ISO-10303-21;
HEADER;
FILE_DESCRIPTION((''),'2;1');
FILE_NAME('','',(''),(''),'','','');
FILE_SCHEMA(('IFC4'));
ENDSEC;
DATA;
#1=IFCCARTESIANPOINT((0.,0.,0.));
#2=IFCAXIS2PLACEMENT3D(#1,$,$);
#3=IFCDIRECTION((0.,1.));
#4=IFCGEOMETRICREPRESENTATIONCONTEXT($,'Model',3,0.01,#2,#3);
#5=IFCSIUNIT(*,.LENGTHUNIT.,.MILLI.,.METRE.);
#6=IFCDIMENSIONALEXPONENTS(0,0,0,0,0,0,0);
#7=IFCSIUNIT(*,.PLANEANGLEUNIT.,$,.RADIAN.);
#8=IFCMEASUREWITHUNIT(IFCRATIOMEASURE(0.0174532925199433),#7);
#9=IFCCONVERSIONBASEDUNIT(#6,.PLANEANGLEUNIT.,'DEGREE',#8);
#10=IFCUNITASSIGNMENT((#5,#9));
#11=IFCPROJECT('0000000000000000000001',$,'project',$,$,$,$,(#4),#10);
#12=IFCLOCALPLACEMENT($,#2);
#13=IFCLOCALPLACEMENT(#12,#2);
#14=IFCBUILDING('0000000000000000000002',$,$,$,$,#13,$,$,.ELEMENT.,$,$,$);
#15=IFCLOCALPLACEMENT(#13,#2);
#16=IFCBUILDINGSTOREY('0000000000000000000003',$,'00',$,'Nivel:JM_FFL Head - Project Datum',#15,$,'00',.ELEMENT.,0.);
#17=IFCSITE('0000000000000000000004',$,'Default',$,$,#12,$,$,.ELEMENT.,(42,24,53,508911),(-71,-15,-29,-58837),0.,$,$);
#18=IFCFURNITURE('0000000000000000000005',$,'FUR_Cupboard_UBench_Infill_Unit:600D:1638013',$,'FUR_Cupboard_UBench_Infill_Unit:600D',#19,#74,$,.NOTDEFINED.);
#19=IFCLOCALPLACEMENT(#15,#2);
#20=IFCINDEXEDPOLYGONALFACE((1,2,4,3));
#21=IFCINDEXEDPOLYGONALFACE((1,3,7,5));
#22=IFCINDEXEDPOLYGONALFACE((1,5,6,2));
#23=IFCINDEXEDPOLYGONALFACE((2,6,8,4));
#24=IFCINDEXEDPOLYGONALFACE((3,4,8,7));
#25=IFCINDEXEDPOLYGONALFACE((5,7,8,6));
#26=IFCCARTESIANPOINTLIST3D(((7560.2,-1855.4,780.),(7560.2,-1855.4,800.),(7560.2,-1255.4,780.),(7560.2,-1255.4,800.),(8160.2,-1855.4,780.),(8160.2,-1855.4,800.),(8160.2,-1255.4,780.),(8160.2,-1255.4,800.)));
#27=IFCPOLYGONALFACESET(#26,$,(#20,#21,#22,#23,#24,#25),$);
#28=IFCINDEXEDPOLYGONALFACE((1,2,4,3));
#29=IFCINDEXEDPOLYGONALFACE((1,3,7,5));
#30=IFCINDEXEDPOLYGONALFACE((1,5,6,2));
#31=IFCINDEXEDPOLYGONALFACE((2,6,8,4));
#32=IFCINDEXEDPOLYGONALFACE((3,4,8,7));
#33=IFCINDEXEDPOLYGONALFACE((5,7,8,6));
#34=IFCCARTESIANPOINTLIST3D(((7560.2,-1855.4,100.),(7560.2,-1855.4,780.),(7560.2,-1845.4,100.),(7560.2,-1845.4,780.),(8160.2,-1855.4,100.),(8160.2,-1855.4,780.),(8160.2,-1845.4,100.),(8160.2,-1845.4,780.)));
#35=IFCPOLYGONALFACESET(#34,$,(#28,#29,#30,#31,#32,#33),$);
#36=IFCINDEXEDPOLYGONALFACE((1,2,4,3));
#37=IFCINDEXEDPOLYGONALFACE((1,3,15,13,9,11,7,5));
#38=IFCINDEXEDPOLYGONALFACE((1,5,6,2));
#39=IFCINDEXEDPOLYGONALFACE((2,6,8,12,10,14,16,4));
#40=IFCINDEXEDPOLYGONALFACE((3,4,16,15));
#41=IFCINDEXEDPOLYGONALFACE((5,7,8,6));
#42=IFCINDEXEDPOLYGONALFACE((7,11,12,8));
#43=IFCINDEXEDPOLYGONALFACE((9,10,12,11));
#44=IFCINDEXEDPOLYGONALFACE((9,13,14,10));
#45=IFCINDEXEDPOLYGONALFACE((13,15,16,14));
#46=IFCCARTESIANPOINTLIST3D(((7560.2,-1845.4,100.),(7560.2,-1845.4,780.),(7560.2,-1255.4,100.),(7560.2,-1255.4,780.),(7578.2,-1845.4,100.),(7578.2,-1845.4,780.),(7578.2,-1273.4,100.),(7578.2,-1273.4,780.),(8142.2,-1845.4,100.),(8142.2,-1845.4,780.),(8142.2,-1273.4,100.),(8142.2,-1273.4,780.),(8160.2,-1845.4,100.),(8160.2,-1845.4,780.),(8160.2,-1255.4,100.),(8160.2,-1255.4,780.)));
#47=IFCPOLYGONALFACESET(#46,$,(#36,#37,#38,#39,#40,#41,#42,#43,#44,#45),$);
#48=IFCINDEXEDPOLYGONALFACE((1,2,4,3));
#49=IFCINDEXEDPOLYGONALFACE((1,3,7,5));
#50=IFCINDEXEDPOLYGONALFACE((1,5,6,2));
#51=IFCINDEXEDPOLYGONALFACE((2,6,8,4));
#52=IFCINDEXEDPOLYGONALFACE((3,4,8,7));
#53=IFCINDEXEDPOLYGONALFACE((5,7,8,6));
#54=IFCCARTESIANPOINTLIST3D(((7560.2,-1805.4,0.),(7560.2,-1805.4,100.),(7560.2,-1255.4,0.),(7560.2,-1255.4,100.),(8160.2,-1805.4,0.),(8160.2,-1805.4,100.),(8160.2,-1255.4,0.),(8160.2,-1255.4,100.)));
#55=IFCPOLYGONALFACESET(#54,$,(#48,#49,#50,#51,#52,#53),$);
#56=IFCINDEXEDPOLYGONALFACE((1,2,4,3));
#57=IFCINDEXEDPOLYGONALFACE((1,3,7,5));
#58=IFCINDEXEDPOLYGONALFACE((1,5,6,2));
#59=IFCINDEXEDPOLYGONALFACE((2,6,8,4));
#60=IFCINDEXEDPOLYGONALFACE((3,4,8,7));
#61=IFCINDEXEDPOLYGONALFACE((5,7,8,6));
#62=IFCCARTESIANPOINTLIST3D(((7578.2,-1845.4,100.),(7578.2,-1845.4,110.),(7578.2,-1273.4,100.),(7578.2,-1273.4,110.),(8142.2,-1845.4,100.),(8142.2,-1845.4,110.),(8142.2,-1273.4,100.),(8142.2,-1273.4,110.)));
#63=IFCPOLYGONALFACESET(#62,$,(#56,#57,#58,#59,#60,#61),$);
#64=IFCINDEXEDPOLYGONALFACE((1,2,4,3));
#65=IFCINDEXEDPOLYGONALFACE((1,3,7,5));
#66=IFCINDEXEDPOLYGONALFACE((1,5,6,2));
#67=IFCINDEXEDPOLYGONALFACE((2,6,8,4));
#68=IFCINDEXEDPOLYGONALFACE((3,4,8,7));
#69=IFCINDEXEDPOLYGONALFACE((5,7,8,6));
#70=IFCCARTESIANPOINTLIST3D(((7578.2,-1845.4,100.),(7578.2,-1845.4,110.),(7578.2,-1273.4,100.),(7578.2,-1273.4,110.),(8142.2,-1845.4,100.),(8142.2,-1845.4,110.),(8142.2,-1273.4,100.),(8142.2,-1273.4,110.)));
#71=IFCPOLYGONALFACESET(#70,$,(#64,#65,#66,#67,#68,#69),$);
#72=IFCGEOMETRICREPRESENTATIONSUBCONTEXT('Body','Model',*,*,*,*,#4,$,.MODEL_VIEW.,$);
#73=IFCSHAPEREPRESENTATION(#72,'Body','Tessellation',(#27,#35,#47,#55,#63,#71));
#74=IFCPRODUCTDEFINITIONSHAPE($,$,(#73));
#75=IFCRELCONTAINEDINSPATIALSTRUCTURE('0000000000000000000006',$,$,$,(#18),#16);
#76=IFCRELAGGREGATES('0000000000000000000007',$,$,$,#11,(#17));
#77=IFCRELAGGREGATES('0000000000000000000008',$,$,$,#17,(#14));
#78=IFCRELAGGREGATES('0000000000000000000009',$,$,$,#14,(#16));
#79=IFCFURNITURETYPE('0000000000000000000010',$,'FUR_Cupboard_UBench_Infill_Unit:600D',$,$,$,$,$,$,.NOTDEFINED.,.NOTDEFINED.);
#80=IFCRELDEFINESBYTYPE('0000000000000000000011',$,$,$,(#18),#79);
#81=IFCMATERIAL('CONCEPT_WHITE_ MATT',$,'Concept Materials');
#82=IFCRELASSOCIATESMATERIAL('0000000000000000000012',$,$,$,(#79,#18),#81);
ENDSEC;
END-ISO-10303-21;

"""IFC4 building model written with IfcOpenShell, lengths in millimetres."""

from ifc_helpers import new_model, entity, si_unit, converted_unit, direction, frame, origin, place, context, subcontext, project, spatial, indexed_curve, outline, extrude, source, transform, mapped, material, type_object, type_shapes, element, save


model = new_model("IFC4")

# Units and contexts
model_context = context("Model", 3, precision=0.01, world=origin(), true_north=direction((0.0, 1.0)))
body_context = subcontext(model_context, "Body", "Model", "MODEL_VIEW")
ifc_project = project(units=[si_unit("LENGTHUNIT", "METRE", prefix="MILLI"), converted_unit("PLANEANGLEUNIT", "DEGREE", entity("IfcRatioMeasure", 0.0174532925199433), si_unit("PLANEANGLEUNIT", "RADIAN"), dimensions=[0, 0, 0, 0, 0, 0, 0])], contexts=[model_context])

# Site, building, storey
site_placement = place(None, origin())
site = spatial("IfcSite", under=ifc_project, at=site_placement, Name="Default", CompositionType="ELEMENT", RefLatitude=(42, 24, 53, 508911), RefLongitude=(-71, -15, -29, -58837), RefElevation=0.0)
building_placement = place(site_placement, origin())
building = spatial("IfcBuilding", under=site, at=building_placement, CompositionType="ELEMENT")
storey_placement = place(building_placement, origin())
storey = spatial("IfcBuildingStorey", under=building, at=storey_placement, Name="00", ObjectType="Nivel:JM_FFL Head - Project Datum", LongName="00", CompositionType="ELEMENT", Elevation=0.0)

# Furniture
ifc_material_1 = material(Name="CONCEPT_WHITE_ MATT", Category="Concept Materials")
furniture_type_1 = type_object("IfcFurnitureType", Name="FUR_Cupboard_UBench_Infill_Unit:600D", AssemblyPlace="NOTDEFINED", PredefinedType="NOTDEFINED", material=ifc_material_1)
shared_shape_1 = source(origin(), body_context, "Body", "SweptSolid", [
    extrude(outline(indexed_curve([(-300.0, -300.0), (300.0, -300.0), (300.0, 300.0), (-300.0, 300.0), (-300.0, -300.0)], self_intersect=False)), frame((44.7, -300.0, 780.0), z_axis=(0.0, 0.0, 1.0), x_axis=(-1.0, 0.0, 0.0)), (0.0, 0.0, 1.0), 20.0),
    extrude(outline(indexed_curve([(-300.0, -5.0), (300.0, -5.0), (300.0, 5.0), (-300.0, 5.0), (-300.0, -5.0)], self_intersect=False)), frame((44.7, -595.0, 100.0), z_axis=(0.0, 0.0, 1.0), x_axis=(-1.0, 0.0, 0.0)), (0.0, 0.0, 1.0), 680.0),
    extrude(outline(indexed_curve([(-300.0, -299.5), (300.0, -299.5), (300.0, 290.5), (282.0, 290.5), (282.0, -281.5), (-282.0, -281.5), (-282.0, 290.5), (-300.0, 290.5), (-300.0, -299.5)], self_intersect=False)), frame((44.7, -299.5, 100.0), z_axis=(0.0, 0.0, 1.0), x_axis=(-1.0, 0.0, 0.0)), (0.0, 0.0, 1.0), 680.0),
    extrude(outline(indexed_curve([(-300.0, -275.0), (300.0, -275.0), (300.0, 275.0), (-300.0, 275.0), (-300.0, -275.0)], self_intersect=False)), frame((44.7, -275.0, 0.0), z_axis=(0.0, 0.0, 1.0), x_axis=(-1.0, 0.0, 0.0)), (0.0, 0.0, 1.0), 100.0),
    extrude(outline(indexed_curve([(-282.0, -286.0), (282.0, -286.0), (282.0, 286.0), (-282.0, 286.0), (-282.0, -286.0)], self_intersect=False)), frame((44.7, -304.0, 100.0), z_axis=(0.0, 0.0, 1.0), x_axis=(-1.0, 0.0, 0.0)), (0.0, 0.0, 1.0), 10.0),
    extrude(outline(indexed_curve([(-282.0, -286.0), (282.0, -286.0), (282.0, 286.0), (-282.0, 286.0), (-282.0, -286.0)], self_intersect=False)), frame((44.7, -304.0, 100.0), z_axis=(0.0, 0.0, 1.0), x_axis=(-1.0, 0.0, 0.0)), (0.0, 0.0, 1.0), 10.0),
])
type_shapes(furniture_type_1, [shared_shape_1])
furniture_1_placement = place(storey_placement, frame((7815.5, -1255.4, 0.0)))
element("IfcFurniture", 1, at=furniture_1_placement, inside=storey, type_object=furniture_type_1, material=ifc_material_1, Name="FUR_Cupboard_UBench_Infill_Unit:600D:1638013", ObjectType="FUR_Cupboard_UBench_Infill_Unit:600D", PredefinedType="NOTDEFINED", context=body_context, shape_type="MappedRepresentation", body=[
    mapped(shared_shape_1, transform((0.0, 0.0, 0.0), scale=1.0)),
])

save(model, "model.ifc")
